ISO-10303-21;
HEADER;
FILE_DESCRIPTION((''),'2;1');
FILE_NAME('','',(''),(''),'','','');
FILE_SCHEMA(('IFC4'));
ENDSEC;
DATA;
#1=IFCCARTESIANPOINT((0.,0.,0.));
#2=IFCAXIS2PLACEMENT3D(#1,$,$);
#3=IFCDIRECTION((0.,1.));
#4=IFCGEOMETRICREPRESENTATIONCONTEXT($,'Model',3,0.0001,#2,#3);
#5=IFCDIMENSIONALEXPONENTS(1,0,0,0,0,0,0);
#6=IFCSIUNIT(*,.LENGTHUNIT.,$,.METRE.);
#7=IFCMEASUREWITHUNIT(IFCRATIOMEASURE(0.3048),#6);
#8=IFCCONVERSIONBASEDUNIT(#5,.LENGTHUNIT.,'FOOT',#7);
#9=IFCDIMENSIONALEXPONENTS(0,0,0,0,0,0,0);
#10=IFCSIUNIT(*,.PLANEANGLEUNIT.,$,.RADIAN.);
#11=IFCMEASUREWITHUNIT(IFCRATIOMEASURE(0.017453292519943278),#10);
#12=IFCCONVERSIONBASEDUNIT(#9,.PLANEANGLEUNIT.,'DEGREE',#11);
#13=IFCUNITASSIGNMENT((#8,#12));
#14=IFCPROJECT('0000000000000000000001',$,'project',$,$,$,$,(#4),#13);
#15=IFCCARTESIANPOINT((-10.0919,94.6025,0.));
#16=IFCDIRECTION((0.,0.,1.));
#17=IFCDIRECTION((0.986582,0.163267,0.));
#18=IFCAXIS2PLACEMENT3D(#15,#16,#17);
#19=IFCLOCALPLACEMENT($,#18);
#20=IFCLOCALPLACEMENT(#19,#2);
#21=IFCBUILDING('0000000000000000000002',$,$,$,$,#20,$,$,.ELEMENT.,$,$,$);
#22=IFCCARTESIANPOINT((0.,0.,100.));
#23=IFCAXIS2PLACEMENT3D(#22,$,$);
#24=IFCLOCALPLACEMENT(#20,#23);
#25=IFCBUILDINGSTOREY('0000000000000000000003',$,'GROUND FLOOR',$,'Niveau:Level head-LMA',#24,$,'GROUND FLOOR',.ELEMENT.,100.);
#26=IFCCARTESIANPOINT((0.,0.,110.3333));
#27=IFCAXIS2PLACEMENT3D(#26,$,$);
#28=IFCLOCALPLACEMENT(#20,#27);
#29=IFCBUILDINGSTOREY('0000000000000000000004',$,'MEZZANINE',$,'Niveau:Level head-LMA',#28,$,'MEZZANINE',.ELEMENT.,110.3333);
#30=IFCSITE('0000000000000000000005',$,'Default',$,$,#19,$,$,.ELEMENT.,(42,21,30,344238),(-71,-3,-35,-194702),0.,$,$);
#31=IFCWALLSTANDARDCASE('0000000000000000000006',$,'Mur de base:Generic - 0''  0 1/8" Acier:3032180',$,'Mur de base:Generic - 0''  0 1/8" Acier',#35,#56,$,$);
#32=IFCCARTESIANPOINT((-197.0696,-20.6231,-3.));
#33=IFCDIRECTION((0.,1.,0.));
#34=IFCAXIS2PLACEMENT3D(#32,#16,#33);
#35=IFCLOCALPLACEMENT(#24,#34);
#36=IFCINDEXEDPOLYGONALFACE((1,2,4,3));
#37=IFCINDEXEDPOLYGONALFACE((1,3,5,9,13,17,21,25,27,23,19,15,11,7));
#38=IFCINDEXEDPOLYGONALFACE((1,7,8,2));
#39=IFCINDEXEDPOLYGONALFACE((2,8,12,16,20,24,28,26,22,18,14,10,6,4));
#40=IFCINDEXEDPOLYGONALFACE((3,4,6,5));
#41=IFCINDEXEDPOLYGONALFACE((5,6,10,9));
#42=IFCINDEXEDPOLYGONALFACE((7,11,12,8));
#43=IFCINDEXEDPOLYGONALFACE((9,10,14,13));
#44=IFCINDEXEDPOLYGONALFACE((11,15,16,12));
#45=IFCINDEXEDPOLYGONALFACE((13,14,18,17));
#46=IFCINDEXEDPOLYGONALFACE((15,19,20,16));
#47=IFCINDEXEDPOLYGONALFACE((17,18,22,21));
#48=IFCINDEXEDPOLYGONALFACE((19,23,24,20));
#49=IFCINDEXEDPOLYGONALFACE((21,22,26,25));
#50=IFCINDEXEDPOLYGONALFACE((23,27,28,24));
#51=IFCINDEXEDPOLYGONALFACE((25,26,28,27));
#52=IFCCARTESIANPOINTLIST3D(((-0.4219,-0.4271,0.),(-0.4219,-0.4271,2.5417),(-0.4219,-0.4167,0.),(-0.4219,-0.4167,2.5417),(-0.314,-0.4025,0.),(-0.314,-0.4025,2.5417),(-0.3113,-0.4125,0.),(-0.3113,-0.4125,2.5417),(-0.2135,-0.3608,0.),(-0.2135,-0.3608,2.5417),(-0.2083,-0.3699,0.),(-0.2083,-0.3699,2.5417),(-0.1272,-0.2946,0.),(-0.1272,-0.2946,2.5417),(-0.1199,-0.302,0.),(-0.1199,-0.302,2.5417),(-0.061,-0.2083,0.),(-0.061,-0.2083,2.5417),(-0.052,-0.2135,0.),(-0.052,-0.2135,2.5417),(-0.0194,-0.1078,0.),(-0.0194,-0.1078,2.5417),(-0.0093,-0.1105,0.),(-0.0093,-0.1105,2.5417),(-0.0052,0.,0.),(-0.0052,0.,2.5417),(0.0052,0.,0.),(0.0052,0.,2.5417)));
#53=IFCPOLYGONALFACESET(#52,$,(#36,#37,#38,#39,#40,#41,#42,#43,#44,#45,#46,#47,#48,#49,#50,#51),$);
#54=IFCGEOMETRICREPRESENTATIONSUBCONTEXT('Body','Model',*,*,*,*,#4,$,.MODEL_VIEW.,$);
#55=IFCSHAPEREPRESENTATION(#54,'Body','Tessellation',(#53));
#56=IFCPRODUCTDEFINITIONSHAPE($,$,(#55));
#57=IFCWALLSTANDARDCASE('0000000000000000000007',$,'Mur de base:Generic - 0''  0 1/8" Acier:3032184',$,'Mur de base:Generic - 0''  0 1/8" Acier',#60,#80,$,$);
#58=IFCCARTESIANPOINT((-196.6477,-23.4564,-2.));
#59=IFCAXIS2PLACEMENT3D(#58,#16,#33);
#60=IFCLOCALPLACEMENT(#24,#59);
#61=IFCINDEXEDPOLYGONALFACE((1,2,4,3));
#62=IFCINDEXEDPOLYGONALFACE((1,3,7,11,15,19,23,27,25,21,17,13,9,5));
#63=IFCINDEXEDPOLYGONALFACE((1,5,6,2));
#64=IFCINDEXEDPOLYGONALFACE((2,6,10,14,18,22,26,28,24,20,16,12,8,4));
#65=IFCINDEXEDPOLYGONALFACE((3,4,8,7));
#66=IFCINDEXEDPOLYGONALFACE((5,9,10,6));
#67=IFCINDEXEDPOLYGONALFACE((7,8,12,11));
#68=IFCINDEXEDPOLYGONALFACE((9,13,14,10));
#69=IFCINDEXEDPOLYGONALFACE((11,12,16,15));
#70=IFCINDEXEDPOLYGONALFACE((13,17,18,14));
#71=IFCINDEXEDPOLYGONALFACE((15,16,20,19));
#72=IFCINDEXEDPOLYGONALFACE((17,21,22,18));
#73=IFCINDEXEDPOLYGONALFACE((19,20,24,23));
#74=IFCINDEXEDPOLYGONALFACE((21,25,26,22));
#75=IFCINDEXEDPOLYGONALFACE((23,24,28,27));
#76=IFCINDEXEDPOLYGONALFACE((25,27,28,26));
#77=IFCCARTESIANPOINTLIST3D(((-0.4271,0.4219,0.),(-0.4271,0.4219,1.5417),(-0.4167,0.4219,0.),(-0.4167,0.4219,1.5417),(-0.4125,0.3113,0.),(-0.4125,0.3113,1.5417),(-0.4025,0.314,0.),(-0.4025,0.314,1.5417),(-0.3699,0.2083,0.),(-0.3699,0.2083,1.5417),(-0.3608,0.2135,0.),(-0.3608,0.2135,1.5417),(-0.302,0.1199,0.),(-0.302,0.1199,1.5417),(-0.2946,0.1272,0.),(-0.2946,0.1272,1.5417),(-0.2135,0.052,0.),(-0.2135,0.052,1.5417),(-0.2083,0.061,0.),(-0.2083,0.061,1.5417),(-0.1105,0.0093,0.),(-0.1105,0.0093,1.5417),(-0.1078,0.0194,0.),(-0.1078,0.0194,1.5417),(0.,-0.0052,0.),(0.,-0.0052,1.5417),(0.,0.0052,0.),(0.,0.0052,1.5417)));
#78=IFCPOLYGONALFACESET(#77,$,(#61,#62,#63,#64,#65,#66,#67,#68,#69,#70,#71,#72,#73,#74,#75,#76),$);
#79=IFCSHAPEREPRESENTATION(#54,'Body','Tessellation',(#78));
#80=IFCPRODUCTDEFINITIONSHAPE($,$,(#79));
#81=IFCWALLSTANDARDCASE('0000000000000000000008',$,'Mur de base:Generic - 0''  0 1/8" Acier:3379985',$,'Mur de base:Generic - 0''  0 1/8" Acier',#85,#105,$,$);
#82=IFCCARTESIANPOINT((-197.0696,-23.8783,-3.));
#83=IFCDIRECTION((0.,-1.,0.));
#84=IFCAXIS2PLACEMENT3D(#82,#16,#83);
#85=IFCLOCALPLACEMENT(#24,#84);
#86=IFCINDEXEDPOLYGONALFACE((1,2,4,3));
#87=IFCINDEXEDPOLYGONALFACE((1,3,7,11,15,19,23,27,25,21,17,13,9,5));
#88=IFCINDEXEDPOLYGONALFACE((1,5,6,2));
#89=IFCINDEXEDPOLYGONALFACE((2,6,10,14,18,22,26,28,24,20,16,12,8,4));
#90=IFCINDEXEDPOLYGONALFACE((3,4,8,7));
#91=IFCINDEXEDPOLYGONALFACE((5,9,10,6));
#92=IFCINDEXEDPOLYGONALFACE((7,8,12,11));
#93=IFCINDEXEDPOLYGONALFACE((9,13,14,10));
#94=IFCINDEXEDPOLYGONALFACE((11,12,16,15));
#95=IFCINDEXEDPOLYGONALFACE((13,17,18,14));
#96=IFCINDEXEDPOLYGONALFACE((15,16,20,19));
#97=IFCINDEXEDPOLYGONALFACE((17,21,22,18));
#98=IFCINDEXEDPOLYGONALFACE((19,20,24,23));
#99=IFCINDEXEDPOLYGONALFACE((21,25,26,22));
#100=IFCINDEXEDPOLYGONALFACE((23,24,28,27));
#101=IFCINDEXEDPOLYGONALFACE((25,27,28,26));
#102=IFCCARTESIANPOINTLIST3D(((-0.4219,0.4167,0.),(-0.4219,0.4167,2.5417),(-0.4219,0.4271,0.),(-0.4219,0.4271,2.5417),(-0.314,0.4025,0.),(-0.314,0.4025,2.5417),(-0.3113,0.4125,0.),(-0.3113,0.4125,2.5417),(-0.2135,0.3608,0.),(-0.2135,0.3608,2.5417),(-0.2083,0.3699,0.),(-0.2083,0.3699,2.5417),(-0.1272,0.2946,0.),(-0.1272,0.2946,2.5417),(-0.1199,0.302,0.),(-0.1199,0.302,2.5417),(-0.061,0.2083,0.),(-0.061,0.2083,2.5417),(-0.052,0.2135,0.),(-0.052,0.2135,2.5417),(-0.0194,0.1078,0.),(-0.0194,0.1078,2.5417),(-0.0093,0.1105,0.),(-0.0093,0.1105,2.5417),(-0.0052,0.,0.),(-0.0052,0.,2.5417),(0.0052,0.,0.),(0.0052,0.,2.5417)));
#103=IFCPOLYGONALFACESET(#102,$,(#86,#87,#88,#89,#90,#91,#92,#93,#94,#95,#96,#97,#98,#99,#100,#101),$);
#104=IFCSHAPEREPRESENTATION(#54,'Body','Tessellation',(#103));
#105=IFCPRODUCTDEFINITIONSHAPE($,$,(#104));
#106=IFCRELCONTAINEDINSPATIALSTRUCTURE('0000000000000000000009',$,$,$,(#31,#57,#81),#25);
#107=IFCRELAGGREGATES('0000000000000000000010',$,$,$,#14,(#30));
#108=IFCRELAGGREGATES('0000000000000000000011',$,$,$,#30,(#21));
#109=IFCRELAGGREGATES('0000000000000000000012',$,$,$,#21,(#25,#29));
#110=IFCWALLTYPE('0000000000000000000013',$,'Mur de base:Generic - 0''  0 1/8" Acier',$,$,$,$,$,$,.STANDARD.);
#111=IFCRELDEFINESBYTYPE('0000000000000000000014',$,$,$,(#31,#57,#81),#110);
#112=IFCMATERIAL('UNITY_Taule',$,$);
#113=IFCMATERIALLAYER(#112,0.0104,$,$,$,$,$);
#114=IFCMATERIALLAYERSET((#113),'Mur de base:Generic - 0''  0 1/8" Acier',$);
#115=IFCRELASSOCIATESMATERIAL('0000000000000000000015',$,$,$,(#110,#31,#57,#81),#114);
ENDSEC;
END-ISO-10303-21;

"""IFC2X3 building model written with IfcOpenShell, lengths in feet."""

from ifc_helpers import new_model, entity, si_unit, converted_unit, direction, frame, frame_2d, origin, place, context, subcontext, project, spatial, polyline, circle_curve, parameter, trimmed, segment, composite_curve, outline, extrude, material, layer, layer_set, layer_usage, type_object, element, save


model = new_model("IFC2X3")

# Units and contexts
model_context = context("Model", 3, precision=0.0001, world=origin(), true_north=direction((0.0, 1.0)))
body_context = subcontext(model_context, "Body", "Model", "MODEL_VIEW")
ifc_project = project(units=[converted_unit("LENGTHUNIT", "FOOT", entity("IfcRatioMeasure", 0.3048), si_unit("LENGTHUNIT", "METRE"), dimensions=[1, 0, 0, 0, 0, 0, 0]), converted_unit("PLANEANGLEUNIT", "DEGREE", entity("IfcRatioMeasure", 0.017453292519943278), si_unit("PLANEANGLEUNIT", "RADIAN"), dimensions=[0, 0, 0, 0, 0, 0, 0])], contexts=[model_context])

# Site, building, storey
site_placement = place(None, frame((-10.0919, 94.6025, 0.0), z_axis=(0.0, 0.0, 1.0), x_axis=(0.986582, 0.163267, 0.0)))
site = spatial("IfcSite", under=ifc_project, at=site_placement, Name="Default", CompositionType="ELEMENT", RefLatitude=(42, 21, 30, 344238), RefLongitude=(-71, -3, -35, -194702), RefElevation=0.0)
building_placement = place(site_placement, origin())
building = spatial("IfcBuilding", under=site, at=building_placement, CompositionType="ELEMENT")
storey_1_placement = place(building_placement, frame((0.0, 0.0, 100.0)))
storey_1 = spatial("IfcBuildingStorey", under=building, at=storey_1_placement, Name="GROUND FLOOR", ObjectType="Niveau:Level head-LMA", LongName="GROUND FLOOR", CompositionType="ELEMENT", Elevation=100.0)

# Shared definitions
storey_2_placement = place(building_placement, frame((0.0, 0.0, 110.3333)))
storey_2 = spatial("IfcBuildingStorey", under=building, at=storey_2_placement, Name="MEZZANINE", ObjectType="Niveau:Level head-LMA", LongName="MEZZANINE", CompositionType="ELEMENT", Elevation=110.3333)

# Walls
ifc_material_1 = material(Name="UNITY_Taule")
ifc_layer_1 = layer(ifc_material_1, 0.0104)
ifc_layer_set_1 = layer_set([ifc_layer_1], Name="Mur de base:Generic - 0'  0 1/8\" Acier")
ifc_layer_usage_1 = layer_usage(ifc_layer_set_1, "AXIS2", "NEGATIVE", 0.0052)
wall_type_1 = type_object("IfcWallType", Name="Mur de base:Generic - 0'  0 1/8\" Acier", PredefinedType="STANDARD", material=ifc_layer_set_1)
wall_1_placement = place(storey_1_placement, frame((-197.0696, -20.6231, -3.0), z_axis=(0.0, 0.0, 1.0), x_axis=(0.0, 1.0, 0.0)))
element("IfcWallStandardCase", 1, at=wall_1_placement, inside=storey_1, type_object=wall_type_1, material=ifc_layer_usage_1, Name="Mur de base:Generic - 0'  0 1/8\" Acier:3032180", ObjectType="Mur de base:Generic - 0'  0 1/8\" Acier", context=body_context, shape_type="SweptSolid", body=[
    extrude(outline(composite_curve([segment(trimmed(circle_curve(frame_2d((-0.4219, 0.0), x_axis=(1.0, 0.0)), 0.4271), [parameter(270.0)], [parameter(360.0)], True, "PARAMETER"), True, "CONTINUOUS"), segment(polyline([(0.0052, 0.0), (-0.0052, 0.0)]), True, "CONTINUOUS"), segment(trimmed(circle_curve(frame_2d((-0.4219, 0.0), x_axis=(1.0, 0.0)), 0.4167), [parameter(270.0)], [parameter(360.0)], True, "PARAMETER"), False, "CONTINUOUS"), segment(polyline([(-0.4219, -0.4167), (-0.4219, -0.4271)]), True, "CONTINUOUS")], self_intersect=False)), origin(), (0.0, 0.0, 1.0), 2.5417),
])
ifc_layer_usage_2 = layer_usage(ifc_layer_set_1, "AXIS2", "NEGATIVE", 0.0052)
wall_2_placement = place(storey_1_placement, frame((-196.6477, -23.4564, -2.0), z_axis=(0.0, 0.0, 1.0), x_axis=(0.0, 1.0, 0.0)))
element("IfcWallStandardCase", 2, at=wall_2_placement, inside=storey_1, type_object=wall_type_1, material=ifc_layer_usage_2, Name="Mur de base:Generic - 0'  0 1/8\" Acier:3032184", ObjectType="Mur de base:Generic - 0'  0 1/8\" Acier", context=body_context, shape_type="SweptSolid", body=[
    extrude(outline(composite_curve([segment(trimmed(circle_curve(frame_2d((0.0, 0.4219), x_axis=(1.0, 0.0)), 0.4271), [parameter(180.0)], [parameter(270.0)], True, "PARAMETER"), True, "CONTINUOUS"), segment(polyline([(0.0, -0.0052), (0.0, 0.0052)]), True, "CONTINUOUS"), segment(trimmed(circle_curve(frame_2d((0.0, 0.4219), x_axis=(1.0, 0.0)), 0.4167), [parameter(180.0)], [parameter(270.0)], True, "PARAMETER"), False, "CONTINUOUS"), segment(polyline([(-0.4167, 0.4219), (-0.4271, 0.4219)]), True, "CONTINUOUS")], self_intersect=False)), origin(), (0.0, 0.0, 1.0), 1.5417),
])
ifc_layer_usage_3 = layer_usage(ifc_layer_set_1, "AXIS2", "NEGATIVE", 0.0052)
wall_3_placement = place(storey_1_placement, frame((-197.0696, -23.8783, -3.0), z_axis=(0.0, 0.0, 1.0), x_axis=(0.0, -1.0, 0.0)))
element("IfcWallStandardCase", 3, at=wall_3_placement, inside=storey_1, type_object=wall_type_1, material=ifc_layer_usage_3, Name="Mur de base:Generic - 0'  0 1/8\" Acier:3379985", ObjectType="Mur de base:Generic - 0'  0 1/8\" Acier", context=body_context, shape_type="SweptSolid", body=[
    extrude(outline(composite_curve([segment(trimmed(circle_curve(frame_2d((-0.4219, 0.0), x_axis=(1.0, 0.0)), 0.4167), [parameter(360.0)], [parameter(90.0)], True, "PARAMETER"), False, "CONTINUOUS"), segment(polyline([(-0.0052, 0.0), (0.0052, 0.0)]), True, "CONTINUOUS"), segment(trimmed(circle_curve(frame_2d((-0.4219, 0.0), x_axis=(1.0, 0.0)), 0.4271), [parameter(360.0)], [parameter(90.0)], True, "PARAMETER"), True, "CONTINUOUS"), segment(polyline([(-0.4219, 0.4271), (-0.4219, 0.4167)]), True, "CONTINUOUS")], self_intersect=False)), origin(), (0.0, 0.0, 1.0), 2.5417),
])

save(model, "model.ifc")
